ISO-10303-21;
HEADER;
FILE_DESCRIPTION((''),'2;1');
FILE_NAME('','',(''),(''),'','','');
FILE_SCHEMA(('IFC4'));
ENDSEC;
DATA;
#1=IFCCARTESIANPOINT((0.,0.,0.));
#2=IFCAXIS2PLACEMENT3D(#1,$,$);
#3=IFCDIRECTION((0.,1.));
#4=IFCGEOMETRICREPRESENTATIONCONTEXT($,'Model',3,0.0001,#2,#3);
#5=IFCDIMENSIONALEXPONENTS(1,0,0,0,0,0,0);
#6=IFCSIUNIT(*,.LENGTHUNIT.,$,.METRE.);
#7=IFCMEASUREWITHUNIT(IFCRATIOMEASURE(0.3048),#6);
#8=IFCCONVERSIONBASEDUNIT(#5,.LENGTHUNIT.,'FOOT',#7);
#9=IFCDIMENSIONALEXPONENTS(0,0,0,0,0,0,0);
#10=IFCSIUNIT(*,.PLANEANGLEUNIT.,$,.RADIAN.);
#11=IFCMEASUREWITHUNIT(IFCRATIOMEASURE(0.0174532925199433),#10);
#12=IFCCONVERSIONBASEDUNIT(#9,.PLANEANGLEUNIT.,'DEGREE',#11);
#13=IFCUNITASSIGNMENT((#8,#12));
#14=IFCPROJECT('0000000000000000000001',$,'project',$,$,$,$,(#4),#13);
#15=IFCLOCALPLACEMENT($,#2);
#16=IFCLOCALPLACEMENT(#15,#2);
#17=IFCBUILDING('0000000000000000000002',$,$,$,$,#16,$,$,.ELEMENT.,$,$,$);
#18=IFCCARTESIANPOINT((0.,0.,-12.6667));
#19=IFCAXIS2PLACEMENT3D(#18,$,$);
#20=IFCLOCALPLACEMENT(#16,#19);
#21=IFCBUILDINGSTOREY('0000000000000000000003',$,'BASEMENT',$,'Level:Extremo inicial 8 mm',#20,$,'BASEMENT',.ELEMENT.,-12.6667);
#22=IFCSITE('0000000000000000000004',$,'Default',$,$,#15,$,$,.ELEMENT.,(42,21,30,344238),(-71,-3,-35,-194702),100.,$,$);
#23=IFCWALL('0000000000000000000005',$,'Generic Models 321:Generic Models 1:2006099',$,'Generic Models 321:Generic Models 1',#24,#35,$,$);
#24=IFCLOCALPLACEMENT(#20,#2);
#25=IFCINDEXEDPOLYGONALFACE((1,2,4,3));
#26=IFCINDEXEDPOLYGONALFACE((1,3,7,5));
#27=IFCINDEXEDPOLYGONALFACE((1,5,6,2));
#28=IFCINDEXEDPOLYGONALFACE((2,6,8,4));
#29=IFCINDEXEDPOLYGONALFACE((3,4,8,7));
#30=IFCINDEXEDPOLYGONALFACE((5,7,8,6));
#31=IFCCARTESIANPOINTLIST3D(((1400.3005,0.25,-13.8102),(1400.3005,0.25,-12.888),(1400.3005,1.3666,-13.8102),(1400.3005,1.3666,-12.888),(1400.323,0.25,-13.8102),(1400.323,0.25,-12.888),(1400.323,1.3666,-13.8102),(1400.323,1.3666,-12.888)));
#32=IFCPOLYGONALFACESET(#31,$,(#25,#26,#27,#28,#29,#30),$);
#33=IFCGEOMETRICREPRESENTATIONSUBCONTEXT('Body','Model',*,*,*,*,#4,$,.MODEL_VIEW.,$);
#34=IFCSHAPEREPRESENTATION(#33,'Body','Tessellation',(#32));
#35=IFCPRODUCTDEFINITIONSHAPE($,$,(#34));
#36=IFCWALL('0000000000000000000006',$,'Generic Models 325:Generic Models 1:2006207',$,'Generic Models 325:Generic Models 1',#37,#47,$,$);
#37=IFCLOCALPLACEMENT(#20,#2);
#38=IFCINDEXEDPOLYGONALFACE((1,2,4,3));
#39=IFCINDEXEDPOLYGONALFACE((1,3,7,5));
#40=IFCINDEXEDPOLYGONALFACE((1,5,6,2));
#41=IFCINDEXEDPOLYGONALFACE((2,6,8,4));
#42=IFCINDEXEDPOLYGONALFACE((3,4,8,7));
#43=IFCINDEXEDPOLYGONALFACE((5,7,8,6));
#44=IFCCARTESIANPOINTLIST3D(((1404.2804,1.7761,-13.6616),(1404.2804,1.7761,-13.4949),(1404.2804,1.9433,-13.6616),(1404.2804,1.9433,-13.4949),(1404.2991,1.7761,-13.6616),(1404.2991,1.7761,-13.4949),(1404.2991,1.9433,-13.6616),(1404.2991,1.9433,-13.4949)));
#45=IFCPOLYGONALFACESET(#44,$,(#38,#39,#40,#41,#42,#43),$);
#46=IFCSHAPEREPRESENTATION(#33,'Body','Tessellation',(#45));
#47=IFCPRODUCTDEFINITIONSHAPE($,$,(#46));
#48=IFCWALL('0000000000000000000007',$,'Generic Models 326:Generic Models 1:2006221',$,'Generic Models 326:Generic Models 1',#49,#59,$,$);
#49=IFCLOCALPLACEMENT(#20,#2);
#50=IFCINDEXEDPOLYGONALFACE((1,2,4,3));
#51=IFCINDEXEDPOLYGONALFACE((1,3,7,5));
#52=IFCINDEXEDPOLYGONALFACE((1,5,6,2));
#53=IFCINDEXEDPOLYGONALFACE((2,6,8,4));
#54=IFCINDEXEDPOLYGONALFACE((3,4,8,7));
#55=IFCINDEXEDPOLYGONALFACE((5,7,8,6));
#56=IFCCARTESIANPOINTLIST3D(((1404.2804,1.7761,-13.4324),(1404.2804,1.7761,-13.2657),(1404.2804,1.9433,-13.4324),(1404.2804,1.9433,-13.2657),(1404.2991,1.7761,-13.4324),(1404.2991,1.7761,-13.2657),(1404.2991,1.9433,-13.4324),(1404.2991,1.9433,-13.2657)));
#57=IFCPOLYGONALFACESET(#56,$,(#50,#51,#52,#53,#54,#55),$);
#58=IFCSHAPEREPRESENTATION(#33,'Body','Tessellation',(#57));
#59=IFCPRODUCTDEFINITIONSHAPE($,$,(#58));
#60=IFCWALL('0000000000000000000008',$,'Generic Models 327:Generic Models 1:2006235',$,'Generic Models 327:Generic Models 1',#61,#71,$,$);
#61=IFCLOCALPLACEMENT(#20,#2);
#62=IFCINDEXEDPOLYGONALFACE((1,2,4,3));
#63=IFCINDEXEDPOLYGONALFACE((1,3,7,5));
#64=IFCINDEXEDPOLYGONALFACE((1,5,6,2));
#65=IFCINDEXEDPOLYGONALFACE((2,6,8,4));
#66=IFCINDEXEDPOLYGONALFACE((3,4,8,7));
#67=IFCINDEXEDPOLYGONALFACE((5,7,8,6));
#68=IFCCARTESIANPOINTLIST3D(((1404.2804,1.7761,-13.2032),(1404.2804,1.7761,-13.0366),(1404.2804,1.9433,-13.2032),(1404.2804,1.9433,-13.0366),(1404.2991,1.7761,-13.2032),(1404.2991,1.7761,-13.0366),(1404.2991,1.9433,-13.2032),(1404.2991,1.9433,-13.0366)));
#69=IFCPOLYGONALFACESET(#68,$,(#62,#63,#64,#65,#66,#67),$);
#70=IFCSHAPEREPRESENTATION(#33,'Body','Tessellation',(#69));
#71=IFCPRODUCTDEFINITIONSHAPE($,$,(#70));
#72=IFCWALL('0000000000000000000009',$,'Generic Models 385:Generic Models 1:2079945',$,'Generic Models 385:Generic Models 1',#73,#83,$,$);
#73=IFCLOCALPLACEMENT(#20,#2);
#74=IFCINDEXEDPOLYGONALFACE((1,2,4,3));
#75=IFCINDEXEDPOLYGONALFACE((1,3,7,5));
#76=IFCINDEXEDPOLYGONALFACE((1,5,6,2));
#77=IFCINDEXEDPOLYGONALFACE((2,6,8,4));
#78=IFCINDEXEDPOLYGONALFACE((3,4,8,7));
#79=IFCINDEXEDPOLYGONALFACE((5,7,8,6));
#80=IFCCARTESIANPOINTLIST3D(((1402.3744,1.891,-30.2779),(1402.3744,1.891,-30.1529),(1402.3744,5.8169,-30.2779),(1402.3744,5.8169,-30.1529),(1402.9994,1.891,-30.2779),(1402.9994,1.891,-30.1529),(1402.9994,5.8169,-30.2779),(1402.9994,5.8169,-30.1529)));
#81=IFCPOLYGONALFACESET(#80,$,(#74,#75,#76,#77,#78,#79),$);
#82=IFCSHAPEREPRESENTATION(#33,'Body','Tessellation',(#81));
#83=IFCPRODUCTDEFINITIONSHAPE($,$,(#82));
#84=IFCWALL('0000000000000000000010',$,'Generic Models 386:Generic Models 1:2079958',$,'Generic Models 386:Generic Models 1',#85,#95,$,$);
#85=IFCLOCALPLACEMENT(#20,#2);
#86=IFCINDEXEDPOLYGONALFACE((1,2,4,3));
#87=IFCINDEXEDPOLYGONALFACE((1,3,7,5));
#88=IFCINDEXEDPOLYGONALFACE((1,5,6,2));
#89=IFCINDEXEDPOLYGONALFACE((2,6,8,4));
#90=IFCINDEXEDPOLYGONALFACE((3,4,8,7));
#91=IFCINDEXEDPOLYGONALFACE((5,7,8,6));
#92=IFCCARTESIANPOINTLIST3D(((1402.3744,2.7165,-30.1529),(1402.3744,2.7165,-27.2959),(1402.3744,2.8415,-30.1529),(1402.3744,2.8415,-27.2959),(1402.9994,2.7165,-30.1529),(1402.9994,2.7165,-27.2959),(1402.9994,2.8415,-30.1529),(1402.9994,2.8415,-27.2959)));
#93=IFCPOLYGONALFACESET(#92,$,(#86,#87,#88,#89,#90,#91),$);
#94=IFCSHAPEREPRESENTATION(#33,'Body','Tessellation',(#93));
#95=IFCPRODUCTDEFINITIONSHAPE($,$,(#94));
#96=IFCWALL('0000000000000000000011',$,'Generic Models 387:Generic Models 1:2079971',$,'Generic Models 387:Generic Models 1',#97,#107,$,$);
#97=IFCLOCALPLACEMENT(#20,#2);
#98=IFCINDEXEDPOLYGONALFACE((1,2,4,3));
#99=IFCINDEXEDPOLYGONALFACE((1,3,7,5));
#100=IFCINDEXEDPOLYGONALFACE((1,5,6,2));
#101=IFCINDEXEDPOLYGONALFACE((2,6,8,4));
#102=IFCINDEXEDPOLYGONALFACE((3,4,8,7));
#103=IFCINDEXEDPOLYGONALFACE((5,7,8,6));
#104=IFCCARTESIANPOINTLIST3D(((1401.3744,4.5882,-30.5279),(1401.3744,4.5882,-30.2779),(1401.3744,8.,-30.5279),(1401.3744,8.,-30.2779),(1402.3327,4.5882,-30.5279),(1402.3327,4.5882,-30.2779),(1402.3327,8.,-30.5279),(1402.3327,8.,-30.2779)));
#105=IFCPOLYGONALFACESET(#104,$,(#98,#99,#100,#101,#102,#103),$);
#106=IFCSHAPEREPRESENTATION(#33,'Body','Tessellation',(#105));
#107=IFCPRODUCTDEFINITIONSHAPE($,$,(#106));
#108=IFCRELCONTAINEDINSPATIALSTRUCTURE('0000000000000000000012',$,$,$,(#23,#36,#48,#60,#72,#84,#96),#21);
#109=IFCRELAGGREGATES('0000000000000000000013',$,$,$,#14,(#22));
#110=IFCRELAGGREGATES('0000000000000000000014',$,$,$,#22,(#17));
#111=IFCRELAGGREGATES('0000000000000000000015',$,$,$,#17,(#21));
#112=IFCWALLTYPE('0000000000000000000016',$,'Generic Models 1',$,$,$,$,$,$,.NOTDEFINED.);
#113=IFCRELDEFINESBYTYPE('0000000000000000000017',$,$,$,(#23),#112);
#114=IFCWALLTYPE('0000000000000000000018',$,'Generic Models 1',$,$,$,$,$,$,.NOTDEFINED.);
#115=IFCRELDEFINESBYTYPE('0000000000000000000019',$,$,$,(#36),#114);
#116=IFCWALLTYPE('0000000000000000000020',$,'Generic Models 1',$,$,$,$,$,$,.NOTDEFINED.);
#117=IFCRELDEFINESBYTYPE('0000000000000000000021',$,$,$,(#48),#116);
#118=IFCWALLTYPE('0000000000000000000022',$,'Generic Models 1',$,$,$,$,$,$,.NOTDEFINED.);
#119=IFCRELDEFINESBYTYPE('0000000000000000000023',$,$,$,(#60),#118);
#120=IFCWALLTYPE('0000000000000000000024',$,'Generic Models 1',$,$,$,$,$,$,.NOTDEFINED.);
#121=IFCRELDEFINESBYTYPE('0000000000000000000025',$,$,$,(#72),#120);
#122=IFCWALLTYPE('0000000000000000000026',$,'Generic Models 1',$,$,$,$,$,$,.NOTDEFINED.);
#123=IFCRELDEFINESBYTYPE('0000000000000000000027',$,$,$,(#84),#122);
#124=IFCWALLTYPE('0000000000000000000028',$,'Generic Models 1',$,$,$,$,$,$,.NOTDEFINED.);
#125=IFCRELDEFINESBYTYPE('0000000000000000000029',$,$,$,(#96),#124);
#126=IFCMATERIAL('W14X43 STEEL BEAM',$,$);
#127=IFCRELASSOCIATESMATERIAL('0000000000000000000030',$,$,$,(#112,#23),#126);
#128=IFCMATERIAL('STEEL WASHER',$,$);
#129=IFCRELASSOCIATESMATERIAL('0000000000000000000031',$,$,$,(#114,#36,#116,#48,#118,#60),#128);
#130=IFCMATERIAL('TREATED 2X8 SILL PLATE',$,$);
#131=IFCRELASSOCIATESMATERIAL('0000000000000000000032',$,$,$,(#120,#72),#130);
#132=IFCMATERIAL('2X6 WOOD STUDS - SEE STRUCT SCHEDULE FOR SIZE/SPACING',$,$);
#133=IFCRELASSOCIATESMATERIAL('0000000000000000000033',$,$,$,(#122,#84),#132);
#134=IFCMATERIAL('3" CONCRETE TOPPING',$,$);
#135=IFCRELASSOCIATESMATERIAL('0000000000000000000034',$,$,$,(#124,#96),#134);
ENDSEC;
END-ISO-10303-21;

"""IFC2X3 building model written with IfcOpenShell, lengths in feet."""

from ifc_helpers import new_model, entity, si_unit, converted_unit, direction, frame, frame_2d, origin, origin_2d_with_axis, place, context, subcontext, project, spatial, rectangle, extrude, material, type_object, element, save


model = new_model("IFC2X3")

# Units and contexts
model_context = context("Model", 3, precision=0.0001, world=origin(), true_north=direction((0.0, 1.0)))
body_context = subcontext(model_context, "Body", "Model", "MODEL_VIEW")
ifc_project = project(units=[converted_unit("LENGTHUNIT", "FOOT", entity("IfcRatioMeasure", 0.3048), si_unit("LENGTHUNIT", "METRE"), dimensions=[1, 0, 0, 0, 0, 0, 0]), converted_unit("PLANEANGLEUNIT", "DEGREE", entity("IfcRatioMeasure", 0.0174532925199433), si_unit("PLANEANGLEUNIT", "RADIAN"), dimensions=[0, 0, 0, 0, 0, 0, 0])], contexts=[model_context])

# Site, building, storey
site_placement = place(None, origin())
site = spatial("IfcSite", under=ifc_project, at=site_placement, Name="Default", CompositionType="ELEMENT", RefLatitude=(42, 21, 30, 344238), RefLongitude=(-71, -3, -35, -194702), RefElevation=100.0)
building_placement = place(site_placement, origin())
building = spatial("IfcBuilding", under=site, at=building_placement, CompositionType="ELEMENT")
storey_placement = place(building_placement, frame((0.0, 0.0, -12.6667)))
storey = spatial("IfcBuildingStorey", under=building, at=storey_placement, Name="BASEMENT", ObjectType="Level:Extremo inicial 8 mm", LongName="BASEMENT", CompositionType="ELEMENT", Elevation=-12.6667)

# Walls
ifc_material_1 = material(Name="W14X43 STEEL BEAM")
wall_type_1 = type_object("IfcWallType", Name="Generic Models 1", PredefinedType="NOTDEFINED", material=ifc_material_1)
wall_1_placement = place(storey_placement, frame((1400.3005, 0.25, -13.8102), z_axis=(0.0, 0.0, 1.0), x_axis=(0.0, 1.0, 0.0)))
element("IfcWall", 1, at=wall_1_placement, inside=storey, type_object=wall_type_1, material=ifc_material_1, Name="Generic Models 321:Generic Models 1:2006099", ObjectType="Generic Models 321:Generic Models 1", context=body_context, shape_type="SweptSolid", body=[
    extrude(rectangle(XDim=1.1166, YDim=0.0225, at=origin_2d_with_axis()), frame((0.5583, -0.0112, 0.0)), (0.0, 0.0, 1.0), 0.9222),
])
ifc_material_2 = material(Name="STEEL WASHER")
wall_type_2 = type_object("IfcWallType", Name="Generic Models 1", PredefinedType="NOTDEFINED", material=ifc_material_2)
wall_2_placement = place(storey_placement, frame((1404.2804, 1.7761, -13.6616), z_axis=(0.0, 0.0, 1.0), x_axis=(0.0, 1.0, 0.0)))
element("IfcWall", 2, at=wall_2_placement, inside=storey, type_object=wall_type_2, material=ifc_material_2, Name="Generic Models 325:Generic Models 1:2006207", ObjectType="Generic Models 325:Generic Models 1", context=body_context, shape_type="SweptSolid", body=[
    extrude(rectangle(XDim=0.1672, YDim=0.0187, at=origin_2d_with_axis()), frame((0.0836, -0.0093, 0.0)), (0.0, 0.0, 1.0), 0.1667),
])
wall_type_3 = type_object("IfcWallType", Name="Generic Models 1", PredefinedType="NOTDEFINED", material=ifc_material_2)
wall_3_placement = place(storey_placement, frame((1404.2804, 1.7761, -13.4324), z_axis=(0.0, 0.0, 1.0), x_axis=(0.0, 1.0, 0.0)))
element("IfcWall", 3, at=wall_3_placement, inside=storey, type_object=wall_type_3, material=ifc_material_2, Name="Generic Models 326:Generic Models 1:2006221", ObjectType="Generic Models 326:Generic Models 1", context=body_context, shape_type="SweptSolid", body=[
    extrude(rectangle(XDim=0.1672, YDim=0.0187, at=origin_2d_with_axis()), frame((0.0836, -0.0093, 0.0)), (0.0, 0.0, 1.0), 0.1667),
])
wall_type_4 = type_object("IfcWallType", Name="Generic Models 1", PredefinedType="NOTDEFINED", material=ifc_material_2)
wall_4_placement = place(storey_placement, frame((1404.2804, 1.7761, -13.2032), z_axis=(0.0, 0.0, 1.0), x_axis=(0.0, 1.0, 0.0)))
element("IfcWall", 4, at=wall_4_placement, inside=storey, type_object=wall_type_4, material=ifc_material_2, Name="Generic Models 327:Generic Models 1:2006235", ObjectType="Generic Models 327:Generic Models 1", context=body_context, shape_type="SweptSolid", body=[
    extrude(rectangle(XDim=0.1672, YDim=0.0187, at=origin_2d_with_axis()), frame((0.0836, -0.0093, 0.0)), (0.0, 0.0, 1.0), 0.1667),
])
ifc_material_3 = material(Name="TREATED 2X8 SILL PLATE")
wall_type_5 = type_object("IfcWallType", Name="Generic Models 1", PredefinedType="NOTDEFINED", material=ifc_material_3)
wall_5_placement = place(storey_placement, frame((1402.3744, 1.891, -30.2779), z_axis=(0.0, 0.0, 1.0), x_axis=(0.0, 1.0, 0.0)))
element("IfcWall", 5, at=wall_5_placement, inside=storey, type_object=wall_type_5, material=ifc_material_3, Name="Generic Models 385:Generic Models 1:2079945", ObjectType="Generic Models 385:Generic Models 1", context=body_context, shape_type="SweptSolid", body=[
    extrude(rectangle(XDim=3.9258, YDim=0.625, at=origin_2d_with_axis()), frame((1.9629, -0.3125, 0.0)), (0.0, 0.0, 1.0), 0.125),
])
ifc_material_4 = material(Name="2X6 WOOD STUDS - SEE STRUCT SCHEDULE FOR SIZE/SPACING")
wall_type_6 = type_object("IfcWallType", Name="Generic Models 1", PredefinedType="NOTDEFINED", material=ifc_material_4)
wall_6_placement = place(storey_placement, frame((1402.3744, 2.7165, -30.1529)))
element("IfcWall", 6, at=wall_6_placement, inside=storey, type_object=wall_type_6, material=ifc_material_4, Name="Generic Models 386:Generic Models 1:2079958", ObjectType="Generic Models 386:Generic Models 1", context=body_context, shape_type="SweptSolid", body=[
    extrude(rectangle(XDim=0.125, YDim=0.625, at=origin_2d_with_axis()), frame((0.3125, 0.0625, 0.0), z_axis=(0.0, 0.0, 1.0), x_axis=(0.0, 1.0, 0.0)), (0.0, 0.0, 1.0), 2.857),
])
ifc_material_5 = material(Name="3\" CONCRETE TOPPING")
wall_type_7 = type_object("IfcWallType", Name="Generic Models 1", PredefinedType="NOTDEFINED", material=ifc_material_5)
wall_7_placement = place(storey_placement, frame((1401.3744, 4.5882, -30.5279), z_axis=(0.0, 0.0, 1.0), x_axis=(0.0, 1.0, 0.0)))
element("IfcWall", 7, at=wall_7_placement, inside=storey, type_object=wall_type_7, material=ifc_material_5, Name="Generic Models 387:Generic Models 1:2079971", ObjectType="Generic Models 387:Generic Models 1", context=body_context, shape_type="SweptSolid", body=[
    extrude(rectangle(XDim=3.4118, YDim=0.9583, at=frame_2d((0.0, 0.0), x_axis=(1.0, 0.0))), frame((1.7059, -0.4792, 0.0)), (0.0, 0.0, 1.0), 0.25),
])

save(model, "model.ifc")
